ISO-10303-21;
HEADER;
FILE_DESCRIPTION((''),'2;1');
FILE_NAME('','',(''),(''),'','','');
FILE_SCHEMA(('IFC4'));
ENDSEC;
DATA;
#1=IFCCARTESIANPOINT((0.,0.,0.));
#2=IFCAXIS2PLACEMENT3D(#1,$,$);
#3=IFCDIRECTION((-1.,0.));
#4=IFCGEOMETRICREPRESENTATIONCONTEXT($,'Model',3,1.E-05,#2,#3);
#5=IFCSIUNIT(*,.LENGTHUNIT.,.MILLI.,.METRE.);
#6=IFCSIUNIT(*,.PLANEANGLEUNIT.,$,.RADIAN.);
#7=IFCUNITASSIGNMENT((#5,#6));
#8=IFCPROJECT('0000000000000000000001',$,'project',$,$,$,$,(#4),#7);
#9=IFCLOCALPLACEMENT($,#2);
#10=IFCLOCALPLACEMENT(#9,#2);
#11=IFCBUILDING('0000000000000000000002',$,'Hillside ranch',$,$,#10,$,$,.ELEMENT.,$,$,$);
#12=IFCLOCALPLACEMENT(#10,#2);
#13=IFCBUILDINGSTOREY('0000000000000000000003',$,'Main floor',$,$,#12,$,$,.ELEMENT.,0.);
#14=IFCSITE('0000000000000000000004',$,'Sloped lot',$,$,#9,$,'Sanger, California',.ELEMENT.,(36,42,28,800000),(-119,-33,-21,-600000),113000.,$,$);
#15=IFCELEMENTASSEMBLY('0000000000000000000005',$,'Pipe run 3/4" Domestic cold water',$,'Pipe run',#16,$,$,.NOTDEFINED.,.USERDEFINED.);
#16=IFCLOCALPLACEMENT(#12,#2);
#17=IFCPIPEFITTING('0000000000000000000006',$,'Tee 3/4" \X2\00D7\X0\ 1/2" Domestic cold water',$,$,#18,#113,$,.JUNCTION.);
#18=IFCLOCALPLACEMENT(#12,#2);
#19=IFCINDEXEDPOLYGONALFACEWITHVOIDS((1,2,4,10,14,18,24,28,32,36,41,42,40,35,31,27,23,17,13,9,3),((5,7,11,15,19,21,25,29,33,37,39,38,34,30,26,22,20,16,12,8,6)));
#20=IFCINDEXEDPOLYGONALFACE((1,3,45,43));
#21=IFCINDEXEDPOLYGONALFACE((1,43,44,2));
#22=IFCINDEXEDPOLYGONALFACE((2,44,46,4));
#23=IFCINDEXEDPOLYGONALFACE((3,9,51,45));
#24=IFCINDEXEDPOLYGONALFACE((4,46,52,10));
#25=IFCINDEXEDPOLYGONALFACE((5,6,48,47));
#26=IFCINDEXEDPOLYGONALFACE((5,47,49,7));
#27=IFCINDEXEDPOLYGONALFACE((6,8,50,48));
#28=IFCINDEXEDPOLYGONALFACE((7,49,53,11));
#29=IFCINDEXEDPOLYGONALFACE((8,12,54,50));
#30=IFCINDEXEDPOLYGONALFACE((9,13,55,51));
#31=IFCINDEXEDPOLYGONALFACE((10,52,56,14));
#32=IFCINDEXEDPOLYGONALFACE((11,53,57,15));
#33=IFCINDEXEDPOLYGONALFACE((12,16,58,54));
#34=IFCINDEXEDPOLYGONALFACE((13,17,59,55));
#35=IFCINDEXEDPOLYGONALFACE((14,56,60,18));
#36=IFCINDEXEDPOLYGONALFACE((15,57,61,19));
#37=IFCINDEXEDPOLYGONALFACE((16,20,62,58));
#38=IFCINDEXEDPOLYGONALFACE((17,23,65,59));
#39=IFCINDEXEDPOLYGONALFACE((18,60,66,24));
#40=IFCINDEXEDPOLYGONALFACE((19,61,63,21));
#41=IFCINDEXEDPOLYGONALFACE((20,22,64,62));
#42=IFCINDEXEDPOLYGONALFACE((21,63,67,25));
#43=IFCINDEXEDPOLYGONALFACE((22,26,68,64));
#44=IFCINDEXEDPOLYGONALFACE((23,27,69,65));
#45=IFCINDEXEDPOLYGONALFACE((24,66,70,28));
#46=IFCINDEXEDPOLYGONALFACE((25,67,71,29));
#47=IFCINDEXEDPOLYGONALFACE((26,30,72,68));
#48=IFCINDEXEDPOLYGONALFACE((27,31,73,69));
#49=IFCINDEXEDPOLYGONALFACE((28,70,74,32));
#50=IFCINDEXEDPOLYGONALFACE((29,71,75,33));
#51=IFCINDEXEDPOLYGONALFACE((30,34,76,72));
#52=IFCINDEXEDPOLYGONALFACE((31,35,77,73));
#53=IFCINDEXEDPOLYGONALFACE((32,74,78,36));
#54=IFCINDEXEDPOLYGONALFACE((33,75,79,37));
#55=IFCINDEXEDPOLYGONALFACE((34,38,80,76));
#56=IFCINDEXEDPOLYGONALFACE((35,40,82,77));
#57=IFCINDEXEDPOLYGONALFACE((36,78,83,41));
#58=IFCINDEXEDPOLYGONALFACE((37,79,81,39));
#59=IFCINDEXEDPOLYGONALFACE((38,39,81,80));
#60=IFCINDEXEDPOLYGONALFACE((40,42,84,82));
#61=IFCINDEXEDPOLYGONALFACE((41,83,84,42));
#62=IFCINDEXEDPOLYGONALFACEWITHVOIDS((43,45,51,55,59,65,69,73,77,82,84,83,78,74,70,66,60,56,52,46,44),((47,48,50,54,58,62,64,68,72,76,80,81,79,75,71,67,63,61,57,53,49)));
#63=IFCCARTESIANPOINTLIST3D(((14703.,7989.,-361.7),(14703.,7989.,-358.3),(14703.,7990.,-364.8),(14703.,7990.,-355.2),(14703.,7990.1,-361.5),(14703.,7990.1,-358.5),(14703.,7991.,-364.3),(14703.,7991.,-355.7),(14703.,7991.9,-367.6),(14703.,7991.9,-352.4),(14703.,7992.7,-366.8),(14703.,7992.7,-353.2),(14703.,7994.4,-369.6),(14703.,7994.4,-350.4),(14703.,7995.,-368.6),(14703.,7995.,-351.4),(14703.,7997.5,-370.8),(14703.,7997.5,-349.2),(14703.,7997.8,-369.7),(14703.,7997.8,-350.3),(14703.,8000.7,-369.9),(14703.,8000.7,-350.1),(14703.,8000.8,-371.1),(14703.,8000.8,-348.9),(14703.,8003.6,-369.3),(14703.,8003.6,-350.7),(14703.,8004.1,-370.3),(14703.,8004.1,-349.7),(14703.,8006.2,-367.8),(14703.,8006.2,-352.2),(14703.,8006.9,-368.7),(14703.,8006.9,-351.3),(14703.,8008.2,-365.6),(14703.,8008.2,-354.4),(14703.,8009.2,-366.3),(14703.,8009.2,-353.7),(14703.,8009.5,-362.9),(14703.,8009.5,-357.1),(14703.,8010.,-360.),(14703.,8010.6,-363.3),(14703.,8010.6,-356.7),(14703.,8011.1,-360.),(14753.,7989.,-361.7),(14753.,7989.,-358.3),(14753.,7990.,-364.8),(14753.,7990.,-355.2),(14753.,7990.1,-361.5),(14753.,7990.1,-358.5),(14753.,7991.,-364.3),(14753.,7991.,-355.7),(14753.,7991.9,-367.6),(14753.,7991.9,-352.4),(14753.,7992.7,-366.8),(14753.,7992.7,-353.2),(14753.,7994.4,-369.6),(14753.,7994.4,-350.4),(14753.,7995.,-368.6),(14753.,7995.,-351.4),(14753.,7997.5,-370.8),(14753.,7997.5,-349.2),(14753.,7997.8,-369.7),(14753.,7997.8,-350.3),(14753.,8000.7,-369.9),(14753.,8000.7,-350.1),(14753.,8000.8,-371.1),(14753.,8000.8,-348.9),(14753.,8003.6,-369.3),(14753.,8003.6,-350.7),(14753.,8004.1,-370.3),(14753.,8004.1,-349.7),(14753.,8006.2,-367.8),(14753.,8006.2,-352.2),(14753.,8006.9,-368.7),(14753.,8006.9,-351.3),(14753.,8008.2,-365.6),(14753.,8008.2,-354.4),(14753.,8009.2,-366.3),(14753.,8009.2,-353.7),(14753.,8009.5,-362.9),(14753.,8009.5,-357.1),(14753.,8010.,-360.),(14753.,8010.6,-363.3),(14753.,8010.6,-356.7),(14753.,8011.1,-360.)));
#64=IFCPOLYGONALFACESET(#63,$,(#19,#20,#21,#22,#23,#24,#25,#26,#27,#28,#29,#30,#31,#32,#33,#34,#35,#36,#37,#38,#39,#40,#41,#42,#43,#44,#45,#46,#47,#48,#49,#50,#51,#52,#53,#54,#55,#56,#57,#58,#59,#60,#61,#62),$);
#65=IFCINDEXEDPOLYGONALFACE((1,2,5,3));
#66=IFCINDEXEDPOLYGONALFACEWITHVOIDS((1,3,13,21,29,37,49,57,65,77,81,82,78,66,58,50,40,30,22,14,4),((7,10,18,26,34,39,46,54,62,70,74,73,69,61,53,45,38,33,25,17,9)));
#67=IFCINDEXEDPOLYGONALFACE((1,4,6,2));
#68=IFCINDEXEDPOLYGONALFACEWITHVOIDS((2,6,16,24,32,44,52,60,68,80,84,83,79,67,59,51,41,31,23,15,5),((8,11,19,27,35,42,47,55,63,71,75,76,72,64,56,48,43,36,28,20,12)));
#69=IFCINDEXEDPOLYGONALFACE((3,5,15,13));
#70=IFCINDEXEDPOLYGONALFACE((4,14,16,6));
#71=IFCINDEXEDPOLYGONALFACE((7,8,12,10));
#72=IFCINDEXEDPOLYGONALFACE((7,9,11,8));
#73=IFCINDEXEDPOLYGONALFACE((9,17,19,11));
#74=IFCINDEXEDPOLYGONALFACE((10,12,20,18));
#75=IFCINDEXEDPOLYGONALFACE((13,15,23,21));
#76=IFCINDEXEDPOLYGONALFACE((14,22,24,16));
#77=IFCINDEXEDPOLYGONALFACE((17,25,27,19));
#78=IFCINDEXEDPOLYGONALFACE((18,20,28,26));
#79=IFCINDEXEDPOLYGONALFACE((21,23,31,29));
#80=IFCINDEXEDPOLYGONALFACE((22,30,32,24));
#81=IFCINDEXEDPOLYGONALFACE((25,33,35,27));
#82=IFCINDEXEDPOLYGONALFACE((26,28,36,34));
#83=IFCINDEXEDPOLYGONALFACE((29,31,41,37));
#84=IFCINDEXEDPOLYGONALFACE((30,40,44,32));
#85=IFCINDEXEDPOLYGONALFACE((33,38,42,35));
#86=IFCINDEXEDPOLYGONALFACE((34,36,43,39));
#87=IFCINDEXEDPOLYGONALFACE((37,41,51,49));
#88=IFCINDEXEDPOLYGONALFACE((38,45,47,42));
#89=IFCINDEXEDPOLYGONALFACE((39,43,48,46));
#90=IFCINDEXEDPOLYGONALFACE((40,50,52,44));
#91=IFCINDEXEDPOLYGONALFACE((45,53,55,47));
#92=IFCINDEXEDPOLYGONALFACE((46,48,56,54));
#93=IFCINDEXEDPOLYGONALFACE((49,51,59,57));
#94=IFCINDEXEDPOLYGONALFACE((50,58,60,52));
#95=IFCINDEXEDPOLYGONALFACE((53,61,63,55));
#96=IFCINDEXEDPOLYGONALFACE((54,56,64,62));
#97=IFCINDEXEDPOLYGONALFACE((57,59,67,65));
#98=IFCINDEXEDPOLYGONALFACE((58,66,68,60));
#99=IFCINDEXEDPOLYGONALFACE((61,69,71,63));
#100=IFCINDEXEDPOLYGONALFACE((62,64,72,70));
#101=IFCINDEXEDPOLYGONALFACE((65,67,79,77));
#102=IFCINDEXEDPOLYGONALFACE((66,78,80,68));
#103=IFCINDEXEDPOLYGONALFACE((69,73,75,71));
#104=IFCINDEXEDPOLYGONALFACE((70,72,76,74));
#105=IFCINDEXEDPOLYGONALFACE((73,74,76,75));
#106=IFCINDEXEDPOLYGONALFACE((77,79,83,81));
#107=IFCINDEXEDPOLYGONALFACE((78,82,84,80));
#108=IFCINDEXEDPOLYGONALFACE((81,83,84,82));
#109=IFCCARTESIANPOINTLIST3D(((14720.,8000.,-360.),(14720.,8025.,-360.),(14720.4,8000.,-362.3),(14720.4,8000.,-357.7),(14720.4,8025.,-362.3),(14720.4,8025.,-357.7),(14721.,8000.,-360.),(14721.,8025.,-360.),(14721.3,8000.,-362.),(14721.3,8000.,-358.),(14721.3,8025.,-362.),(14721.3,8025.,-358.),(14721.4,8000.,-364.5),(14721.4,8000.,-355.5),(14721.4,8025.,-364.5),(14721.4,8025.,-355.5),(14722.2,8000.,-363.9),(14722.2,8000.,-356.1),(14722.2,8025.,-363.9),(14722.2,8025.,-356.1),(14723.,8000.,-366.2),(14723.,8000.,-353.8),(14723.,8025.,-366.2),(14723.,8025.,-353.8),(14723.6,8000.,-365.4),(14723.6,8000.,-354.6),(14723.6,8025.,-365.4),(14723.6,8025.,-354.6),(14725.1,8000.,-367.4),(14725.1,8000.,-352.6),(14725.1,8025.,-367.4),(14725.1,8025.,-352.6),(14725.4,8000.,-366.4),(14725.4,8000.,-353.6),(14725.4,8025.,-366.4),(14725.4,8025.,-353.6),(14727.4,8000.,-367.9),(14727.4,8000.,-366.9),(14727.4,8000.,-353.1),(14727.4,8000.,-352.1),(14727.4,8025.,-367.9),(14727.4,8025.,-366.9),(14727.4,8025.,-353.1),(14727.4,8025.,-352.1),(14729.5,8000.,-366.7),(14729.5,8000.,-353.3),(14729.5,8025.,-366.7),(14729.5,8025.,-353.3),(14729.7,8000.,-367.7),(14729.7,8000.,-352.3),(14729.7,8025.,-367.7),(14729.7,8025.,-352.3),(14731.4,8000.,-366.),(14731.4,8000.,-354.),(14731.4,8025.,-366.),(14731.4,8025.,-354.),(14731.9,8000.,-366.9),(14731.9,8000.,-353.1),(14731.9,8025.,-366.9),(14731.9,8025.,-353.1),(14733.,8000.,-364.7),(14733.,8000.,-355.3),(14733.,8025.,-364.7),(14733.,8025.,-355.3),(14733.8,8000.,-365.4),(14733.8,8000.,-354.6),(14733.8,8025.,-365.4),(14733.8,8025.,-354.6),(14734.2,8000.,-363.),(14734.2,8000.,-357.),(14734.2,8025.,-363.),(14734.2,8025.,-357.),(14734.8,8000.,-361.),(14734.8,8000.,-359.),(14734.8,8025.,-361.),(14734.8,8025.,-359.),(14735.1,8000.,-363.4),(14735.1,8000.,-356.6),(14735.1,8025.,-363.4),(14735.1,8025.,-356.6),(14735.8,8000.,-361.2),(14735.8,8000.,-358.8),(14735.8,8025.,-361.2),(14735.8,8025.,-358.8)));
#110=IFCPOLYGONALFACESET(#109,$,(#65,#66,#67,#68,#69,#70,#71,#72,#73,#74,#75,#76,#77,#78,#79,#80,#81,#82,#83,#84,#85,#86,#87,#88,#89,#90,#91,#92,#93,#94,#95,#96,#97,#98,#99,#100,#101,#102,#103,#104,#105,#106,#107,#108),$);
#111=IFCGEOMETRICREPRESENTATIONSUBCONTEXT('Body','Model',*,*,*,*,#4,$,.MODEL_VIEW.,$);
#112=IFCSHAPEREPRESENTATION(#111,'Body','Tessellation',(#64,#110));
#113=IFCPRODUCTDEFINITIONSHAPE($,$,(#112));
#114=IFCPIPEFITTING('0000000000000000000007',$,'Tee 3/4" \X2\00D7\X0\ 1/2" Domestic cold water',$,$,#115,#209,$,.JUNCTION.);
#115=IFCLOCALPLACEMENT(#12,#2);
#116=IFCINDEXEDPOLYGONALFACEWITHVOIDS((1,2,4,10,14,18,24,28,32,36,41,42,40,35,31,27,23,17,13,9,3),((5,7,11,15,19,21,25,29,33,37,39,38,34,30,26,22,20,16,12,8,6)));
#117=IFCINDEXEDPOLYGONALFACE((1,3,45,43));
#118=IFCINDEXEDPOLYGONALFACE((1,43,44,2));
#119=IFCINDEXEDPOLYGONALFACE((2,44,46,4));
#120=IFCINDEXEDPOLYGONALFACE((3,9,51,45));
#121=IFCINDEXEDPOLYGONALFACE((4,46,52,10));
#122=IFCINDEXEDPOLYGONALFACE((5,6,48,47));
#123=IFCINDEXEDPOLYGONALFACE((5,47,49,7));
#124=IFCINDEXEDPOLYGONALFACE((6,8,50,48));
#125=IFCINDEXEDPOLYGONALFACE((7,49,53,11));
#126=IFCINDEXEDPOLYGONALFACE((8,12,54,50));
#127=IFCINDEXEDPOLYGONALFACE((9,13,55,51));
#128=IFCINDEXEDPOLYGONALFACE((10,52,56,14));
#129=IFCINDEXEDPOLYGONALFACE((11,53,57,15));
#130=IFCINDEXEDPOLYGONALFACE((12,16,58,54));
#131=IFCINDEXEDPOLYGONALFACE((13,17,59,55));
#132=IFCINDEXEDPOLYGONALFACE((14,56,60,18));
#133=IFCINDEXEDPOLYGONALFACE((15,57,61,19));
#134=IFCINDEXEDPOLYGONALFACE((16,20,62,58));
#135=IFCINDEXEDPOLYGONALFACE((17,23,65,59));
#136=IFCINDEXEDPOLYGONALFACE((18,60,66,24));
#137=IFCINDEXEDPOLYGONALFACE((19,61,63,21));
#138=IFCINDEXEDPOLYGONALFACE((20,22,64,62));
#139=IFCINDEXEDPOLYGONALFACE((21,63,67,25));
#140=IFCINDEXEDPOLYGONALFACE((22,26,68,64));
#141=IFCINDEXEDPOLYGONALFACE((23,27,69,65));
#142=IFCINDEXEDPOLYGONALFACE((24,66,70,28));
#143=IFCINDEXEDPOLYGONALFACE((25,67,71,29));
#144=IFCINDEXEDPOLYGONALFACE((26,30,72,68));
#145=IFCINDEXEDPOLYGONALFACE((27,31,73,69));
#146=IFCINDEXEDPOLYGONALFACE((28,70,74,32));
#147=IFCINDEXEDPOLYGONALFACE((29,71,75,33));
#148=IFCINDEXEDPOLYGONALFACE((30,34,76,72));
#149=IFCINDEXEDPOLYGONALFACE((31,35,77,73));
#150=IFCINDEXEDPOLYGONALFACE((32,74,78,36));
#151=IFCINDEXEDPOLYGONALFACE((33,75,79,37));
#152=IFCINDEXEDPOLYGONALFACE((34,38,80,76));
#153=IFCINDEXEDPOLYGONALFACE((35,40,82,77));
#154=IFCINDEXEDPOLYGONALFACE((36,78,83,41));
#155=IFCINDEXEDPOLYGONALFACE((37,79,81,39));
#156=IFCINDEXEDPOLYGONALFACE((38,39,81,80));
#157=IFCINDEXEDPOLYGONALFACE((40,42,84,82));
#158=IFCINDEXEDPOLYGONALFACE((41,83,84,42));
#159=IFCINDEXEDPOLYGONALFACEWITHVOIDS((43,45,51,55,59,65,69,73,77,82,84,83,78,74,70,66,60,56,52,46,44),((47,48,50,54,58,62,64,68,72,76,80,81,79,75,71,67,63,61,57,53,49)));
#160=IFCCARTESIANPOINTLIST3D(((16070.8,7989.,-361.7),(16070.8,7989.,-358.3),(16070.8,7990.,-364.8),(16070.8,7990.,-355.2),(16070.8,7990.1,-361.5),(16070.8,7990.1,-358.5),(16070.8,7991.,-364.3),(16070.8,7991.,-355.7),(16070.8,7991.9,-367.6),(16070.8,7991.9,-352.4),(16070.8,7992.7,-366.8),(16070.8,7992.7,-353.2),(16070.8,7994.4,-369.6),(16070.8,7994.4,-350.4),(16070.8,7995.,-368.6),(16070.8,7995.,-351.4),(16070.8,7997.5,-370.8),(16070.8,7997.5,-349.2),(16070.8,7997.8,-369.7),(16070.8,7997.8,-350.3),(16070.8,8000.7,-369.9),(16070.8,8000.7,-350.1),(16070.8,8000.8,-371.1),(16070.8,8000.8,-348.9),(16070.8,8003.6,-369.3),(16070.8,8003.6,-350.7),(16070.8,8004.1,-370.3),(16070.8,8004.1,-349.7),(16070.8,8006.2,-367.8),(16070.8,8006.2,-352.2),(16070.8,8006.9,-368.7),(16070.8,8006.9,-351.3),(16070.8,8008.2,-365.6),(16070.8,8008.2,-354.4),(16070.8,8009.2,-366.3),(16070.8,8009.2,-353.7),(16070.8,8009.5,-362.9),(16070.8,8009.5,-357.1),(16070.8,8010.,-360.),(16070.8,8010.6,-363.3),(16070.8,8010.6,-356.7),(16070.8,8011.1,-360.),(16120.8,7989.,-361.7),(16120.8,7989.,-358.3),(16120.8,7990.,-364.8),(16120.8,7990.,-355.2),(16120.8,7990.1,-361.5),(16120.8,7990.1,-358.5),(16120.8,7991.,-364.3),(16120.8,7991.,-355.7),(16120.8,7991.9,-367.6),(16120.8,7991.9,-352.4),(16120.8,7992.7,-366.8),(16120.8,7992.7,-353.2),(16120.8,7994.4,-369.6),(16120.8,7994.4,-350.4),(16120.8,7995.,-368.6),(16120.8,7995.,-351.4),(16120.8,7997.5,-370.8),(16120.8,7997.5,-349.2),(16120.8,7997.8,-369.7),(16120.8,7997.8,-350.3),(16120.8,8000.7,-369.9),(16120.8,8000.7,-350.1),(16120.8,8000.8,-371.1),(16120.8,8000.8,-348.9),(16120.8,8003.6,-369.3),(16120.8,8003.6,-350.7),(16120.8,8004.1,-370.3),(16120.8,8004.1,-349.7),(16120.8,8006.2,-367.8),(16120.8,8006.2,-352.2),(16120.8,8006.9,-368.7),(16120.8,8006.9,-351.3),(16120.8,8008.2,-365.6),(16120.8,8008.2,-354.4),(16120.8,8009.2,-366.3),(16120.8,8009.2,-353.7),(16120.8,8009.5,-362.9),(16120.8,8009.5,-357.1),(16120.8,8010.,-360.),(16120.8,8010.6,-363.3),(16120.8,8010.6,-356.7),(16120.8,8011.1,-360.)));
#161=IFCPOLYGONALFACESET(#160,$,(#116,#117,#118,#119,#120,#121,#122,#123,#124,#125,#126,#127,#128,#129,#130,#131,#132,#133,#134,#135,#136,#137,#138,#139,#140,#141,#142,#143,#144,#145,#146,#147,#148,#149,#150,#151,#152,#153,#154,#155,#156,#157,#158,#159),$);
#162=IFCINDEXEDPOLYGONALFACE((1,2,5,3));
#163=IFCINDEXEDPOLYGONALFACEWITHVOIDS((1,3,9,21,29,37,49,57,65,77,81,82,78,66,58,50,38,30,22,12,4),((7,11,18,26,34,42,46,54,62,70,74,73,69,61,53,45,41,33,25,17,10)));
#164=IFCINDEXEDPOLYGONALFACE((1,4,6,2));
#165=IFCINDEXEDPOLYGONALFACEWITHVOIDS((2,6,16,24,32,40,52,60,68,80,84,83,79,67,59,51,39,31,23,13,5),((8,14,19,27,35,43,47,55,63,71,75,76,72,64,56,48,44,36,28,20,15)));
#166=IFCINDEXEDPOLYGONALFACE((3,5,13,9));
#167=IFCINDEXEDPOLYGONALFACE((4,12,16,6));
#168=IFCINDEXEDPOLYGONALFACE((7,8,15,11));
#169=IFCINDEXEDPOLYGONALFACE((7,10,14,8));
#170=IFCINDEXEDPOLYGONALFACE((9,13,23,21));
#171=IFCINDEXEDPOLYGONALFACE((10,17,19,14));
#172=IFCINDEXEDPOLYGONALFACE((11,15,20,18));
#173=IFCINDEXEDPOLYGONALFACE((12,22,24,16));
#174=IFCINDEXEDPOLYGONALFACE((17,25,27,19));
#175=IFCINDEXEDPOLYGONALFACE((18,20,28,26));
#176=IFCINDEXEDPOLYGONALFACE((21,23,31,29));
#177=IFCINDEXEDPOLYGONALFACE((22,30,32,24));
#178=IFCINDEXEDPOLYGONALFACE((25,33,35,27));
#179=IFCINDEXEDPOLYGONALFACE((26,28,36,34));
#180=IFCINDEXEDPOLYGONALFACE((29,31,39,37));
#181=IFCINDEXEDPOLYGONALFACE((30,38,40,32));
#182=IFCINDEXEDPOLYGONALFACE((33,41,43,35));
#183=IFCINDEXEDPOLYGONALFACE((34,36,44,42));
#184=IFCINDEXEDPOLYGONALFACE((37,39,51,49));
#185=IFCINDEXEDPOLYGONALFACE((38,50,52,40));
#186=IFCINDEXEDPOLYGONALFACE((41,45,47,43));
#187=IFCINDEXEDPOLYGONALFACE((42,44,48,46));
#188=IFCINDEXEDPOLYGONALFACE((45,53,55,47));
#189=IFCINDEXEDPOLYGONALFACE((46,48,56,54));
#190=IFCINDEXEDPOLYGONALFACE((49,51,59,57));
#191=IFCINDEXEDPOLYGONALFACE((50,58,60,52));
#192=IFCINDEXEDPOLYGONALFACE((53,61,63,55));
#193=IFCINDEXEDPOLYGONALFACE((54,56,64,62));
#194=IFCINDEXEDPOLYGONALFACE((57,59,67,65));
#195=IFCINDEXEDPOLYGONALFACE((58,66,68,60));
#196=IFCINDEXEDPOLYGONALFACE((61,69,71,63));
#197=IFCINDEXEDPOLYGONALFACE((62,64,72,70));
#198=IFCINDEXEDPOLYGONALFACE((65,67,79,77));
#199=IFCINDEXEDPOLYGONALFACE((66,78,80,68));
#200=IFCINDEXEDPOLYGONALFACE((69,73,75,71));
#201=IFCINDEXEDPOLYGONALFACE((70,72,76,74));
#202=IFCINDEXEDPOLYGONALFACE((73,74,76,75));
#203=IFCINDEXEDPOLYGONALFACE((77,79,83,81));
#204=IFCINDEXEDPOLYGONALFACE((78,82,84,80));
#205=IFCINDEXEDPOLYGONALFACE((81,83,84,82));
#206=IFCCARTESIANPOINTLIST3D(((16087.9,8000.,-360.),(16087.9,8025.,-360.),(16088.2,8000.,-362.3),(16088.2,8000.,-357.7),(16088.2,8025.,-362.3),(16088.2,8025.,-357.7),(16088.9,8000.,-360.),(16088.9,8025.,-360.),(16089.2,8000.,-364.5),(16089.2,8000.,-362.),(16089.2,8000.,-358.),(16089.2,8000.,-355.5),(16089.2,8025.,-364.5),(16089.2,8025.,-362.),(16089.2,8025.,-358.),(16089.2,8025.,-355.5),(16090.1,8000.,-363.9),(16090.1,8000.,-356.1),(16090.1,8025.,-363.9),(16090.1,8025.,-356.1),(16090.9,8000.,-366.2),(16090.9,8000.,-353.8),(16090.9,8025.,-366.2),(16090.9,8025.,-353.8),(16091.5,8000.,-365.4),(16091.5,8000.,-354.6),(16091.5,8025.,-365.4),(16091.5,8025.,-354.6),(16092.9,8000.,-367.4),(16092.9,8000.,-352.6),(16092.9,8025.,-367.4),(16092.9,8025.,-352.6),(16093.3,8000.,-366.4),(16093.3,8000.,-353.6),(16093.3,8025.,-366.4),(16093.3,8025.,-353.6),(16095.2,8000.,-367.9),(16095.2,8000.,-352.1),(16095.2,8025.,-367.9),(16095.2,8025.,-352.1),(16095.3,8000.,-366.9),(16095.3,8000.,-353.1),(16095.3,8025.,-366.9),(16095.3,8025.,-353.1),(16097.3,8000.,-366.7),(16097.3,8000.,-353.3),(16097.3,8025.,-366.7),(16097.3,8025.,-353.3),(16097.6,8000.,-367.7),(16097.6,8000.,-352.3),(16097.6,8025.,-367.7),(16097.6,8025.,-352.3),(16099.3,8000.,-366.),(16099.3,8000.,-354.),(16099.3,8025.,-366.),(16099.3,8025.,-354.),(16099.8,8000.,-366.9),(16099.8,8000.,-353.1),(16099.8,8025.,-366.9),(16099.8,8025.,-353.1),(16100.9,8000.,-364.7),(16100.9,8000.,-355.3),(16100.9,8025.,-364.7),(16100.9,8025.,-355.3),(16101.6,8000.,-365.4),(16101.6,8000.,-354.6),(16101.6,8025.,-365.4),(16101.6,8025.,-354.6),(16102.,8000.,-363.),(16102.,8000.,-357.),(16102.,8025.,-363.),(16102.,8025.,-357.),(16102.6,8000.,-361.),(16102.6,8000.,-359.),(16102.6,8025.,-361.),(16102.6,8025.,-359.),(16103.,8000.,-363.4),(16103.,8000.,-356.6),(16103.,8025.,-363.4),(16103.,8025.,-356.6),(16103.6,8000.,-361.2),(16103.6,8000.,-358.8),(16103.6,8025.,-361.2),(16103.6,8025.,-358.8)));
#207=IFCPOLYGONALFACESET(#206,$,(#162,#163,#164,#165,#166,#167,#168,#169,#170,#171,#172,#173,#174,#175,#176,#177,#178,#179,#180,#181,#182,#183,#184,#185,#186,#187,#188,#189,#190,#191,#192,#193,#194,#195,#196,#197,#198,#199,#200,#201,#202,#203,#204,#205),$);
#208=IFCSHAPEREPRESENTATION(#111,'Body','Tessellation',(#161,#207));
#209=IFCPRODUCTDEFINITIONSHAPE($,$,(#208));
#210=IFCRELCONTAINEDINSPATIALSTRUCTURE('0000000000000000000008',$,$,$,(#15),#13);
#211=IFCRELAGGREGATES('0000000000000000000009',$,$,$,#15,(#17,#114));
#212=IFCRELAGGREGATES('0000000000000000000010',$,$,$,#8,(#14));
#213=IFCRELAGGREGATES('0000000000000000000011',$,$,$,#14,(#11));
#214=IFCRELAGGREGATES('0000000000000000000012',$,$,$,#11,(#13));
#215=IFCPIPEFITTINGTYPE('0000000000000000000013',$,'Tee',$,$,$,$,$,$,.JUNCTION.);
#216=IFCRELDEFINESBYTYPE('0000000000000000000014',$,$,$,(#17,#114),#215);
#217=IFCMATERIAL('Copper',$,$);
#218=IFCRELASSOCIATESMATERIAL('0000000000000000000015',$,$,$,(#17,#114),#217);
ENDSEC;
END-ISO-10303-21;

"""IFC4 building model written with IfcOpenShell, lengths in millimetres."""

from ifc_helpers import new_model, si_unit, direction, frame, origin, origin_with_axes, origin_2d, place, context, subcontext, project, spatial, hollow_circle, extrude, material, type_object, element, aggregate, save


model = new_model("IFC4")

# Units and contexts
model_context = context("Model", 3, precision=1e-05, world=origin(), true_north=direction((-1.0, 0.0)))
body_context = subcontext(model_context, "Body", "Model", "MODEL_VIEW")
ifc_project = project(units=[si_unit("LENGTHUNIT", "METRE", prefix="MILLI"), si_unit("PLANEANGLEUNIT", "RADIAN")], contexts=[model_context])

# Site, building, storey
site_placement = place(None, origin())
site = spatial("IfcSite", under=ifc_project, at=site_placement, Name="Sloped lot", LongName="Sanger, California", CompositionType="ELEMENT", RefLatitude=(36, 42, 28, 800000), RefLongitude=(-119, -33, -21, -600000), RefElevation=113000.0)
building_placement = place(site_placement, origin())
building = spatial("IfcBuilding", under=site, at=building_placement, Name="Hillside ranch", CompositionType="ELEMENT")
storey_placement = place(building_placement, origin())
storey = spatial("IfcBuildingStorey", under=building, at=storey_placement, Name="Main floor", CompositionType="ELEMENT", Elevation=0.0)

# Element assembly, pipe fittings
assembly_1_placement = place(storey_placement, origin_with_axes())
assembly_1 = element("IfcElementAssembly", 1, at=assembly_1_placement, inside=storey, Name="Pipe run 3/4\" Domestic cold water", ObjectType="Pipe run", AssemblyPlace="NOTDEFINED", PredefinedType="USERDEFINED")
ifc_material = material(Name="Copper")
pipe_fitting_type_1 = type_object("IfcPipeFittingType", Name="Tee", PredefinedType="JUNCTION")
pipe_fitting_1_placement = place(storey_placement, origin_with_axes())
pipe_fitting_1 = element("IfcPipeFitting", 2, at=pipe_fitting_1_placement, type_object=pipe_fitting_type_1, material=ifc_material, Name="Tee 3/4\" × 1/2\" Domestic cold water", PredefinedType="JUNCTION", context=body_context, shape_type="SweptSolid", body=[
    extrude(hollow_circle(Radius=11.1, WallThickness=1.1, at=origin_2d()), frame((14703.0, 8000.0, -360.0), z_axis=(1.0, 0.0, 0.0), x_axis=(0.0, 1.0, 0.0)), (0.0, 0.0, 1.0), 50.0),
    extrude(hollow_circle(Radius=7.9, WallThickness=1.0, at=origin_2d()), frame((14728.0, 8000.0, -360.0), z_axis=(0.0, 1.0, 0.0), x_axis=(-1.0, 0.0, 0.0)), (0.0, 0.0, 1.0), 25.0),
])
pipe_fitting_2_placement = place(storey_placement, origin_with_axes())
pipe_fitting_2 = element("IfcPipeFitting", 3, at=pipe_fitting_2_placement, type_object=pipe_fitting_type_1, material=ifc_material, Name="Tee 3/4\" × 1/2\" Domestic cold water", PredefinedType="JUNCTION", context=body_context, shape_type="SweptSolid", body=[
    extrude(hollow_circle(Radius=11.1, WallThickness=1.1, at=origin_2d()), frame((16070.8, 8000.0, -360.0), z_axis=(1.0, 0.0, 0.0), x_axis=(0.0, 1.0, 0.0)), (0.0, 0.0, 1.0), 50.0),
    extrude(hollow_circle(Radius=7.9, WallThickness=1.0, at=origin_2d()), frame((16095.8, 8000.0, -360.0), z_axis=(0.0, 1.0, 0.0), x_axis=(-1.0, 0.0, 0.0)), (0.0, 0.0, 1.0), 25.0),
])

aggregate(assembly_1, [pipe_fitting_1, pipe_fitting_2])

save(model, "model.ifc")
